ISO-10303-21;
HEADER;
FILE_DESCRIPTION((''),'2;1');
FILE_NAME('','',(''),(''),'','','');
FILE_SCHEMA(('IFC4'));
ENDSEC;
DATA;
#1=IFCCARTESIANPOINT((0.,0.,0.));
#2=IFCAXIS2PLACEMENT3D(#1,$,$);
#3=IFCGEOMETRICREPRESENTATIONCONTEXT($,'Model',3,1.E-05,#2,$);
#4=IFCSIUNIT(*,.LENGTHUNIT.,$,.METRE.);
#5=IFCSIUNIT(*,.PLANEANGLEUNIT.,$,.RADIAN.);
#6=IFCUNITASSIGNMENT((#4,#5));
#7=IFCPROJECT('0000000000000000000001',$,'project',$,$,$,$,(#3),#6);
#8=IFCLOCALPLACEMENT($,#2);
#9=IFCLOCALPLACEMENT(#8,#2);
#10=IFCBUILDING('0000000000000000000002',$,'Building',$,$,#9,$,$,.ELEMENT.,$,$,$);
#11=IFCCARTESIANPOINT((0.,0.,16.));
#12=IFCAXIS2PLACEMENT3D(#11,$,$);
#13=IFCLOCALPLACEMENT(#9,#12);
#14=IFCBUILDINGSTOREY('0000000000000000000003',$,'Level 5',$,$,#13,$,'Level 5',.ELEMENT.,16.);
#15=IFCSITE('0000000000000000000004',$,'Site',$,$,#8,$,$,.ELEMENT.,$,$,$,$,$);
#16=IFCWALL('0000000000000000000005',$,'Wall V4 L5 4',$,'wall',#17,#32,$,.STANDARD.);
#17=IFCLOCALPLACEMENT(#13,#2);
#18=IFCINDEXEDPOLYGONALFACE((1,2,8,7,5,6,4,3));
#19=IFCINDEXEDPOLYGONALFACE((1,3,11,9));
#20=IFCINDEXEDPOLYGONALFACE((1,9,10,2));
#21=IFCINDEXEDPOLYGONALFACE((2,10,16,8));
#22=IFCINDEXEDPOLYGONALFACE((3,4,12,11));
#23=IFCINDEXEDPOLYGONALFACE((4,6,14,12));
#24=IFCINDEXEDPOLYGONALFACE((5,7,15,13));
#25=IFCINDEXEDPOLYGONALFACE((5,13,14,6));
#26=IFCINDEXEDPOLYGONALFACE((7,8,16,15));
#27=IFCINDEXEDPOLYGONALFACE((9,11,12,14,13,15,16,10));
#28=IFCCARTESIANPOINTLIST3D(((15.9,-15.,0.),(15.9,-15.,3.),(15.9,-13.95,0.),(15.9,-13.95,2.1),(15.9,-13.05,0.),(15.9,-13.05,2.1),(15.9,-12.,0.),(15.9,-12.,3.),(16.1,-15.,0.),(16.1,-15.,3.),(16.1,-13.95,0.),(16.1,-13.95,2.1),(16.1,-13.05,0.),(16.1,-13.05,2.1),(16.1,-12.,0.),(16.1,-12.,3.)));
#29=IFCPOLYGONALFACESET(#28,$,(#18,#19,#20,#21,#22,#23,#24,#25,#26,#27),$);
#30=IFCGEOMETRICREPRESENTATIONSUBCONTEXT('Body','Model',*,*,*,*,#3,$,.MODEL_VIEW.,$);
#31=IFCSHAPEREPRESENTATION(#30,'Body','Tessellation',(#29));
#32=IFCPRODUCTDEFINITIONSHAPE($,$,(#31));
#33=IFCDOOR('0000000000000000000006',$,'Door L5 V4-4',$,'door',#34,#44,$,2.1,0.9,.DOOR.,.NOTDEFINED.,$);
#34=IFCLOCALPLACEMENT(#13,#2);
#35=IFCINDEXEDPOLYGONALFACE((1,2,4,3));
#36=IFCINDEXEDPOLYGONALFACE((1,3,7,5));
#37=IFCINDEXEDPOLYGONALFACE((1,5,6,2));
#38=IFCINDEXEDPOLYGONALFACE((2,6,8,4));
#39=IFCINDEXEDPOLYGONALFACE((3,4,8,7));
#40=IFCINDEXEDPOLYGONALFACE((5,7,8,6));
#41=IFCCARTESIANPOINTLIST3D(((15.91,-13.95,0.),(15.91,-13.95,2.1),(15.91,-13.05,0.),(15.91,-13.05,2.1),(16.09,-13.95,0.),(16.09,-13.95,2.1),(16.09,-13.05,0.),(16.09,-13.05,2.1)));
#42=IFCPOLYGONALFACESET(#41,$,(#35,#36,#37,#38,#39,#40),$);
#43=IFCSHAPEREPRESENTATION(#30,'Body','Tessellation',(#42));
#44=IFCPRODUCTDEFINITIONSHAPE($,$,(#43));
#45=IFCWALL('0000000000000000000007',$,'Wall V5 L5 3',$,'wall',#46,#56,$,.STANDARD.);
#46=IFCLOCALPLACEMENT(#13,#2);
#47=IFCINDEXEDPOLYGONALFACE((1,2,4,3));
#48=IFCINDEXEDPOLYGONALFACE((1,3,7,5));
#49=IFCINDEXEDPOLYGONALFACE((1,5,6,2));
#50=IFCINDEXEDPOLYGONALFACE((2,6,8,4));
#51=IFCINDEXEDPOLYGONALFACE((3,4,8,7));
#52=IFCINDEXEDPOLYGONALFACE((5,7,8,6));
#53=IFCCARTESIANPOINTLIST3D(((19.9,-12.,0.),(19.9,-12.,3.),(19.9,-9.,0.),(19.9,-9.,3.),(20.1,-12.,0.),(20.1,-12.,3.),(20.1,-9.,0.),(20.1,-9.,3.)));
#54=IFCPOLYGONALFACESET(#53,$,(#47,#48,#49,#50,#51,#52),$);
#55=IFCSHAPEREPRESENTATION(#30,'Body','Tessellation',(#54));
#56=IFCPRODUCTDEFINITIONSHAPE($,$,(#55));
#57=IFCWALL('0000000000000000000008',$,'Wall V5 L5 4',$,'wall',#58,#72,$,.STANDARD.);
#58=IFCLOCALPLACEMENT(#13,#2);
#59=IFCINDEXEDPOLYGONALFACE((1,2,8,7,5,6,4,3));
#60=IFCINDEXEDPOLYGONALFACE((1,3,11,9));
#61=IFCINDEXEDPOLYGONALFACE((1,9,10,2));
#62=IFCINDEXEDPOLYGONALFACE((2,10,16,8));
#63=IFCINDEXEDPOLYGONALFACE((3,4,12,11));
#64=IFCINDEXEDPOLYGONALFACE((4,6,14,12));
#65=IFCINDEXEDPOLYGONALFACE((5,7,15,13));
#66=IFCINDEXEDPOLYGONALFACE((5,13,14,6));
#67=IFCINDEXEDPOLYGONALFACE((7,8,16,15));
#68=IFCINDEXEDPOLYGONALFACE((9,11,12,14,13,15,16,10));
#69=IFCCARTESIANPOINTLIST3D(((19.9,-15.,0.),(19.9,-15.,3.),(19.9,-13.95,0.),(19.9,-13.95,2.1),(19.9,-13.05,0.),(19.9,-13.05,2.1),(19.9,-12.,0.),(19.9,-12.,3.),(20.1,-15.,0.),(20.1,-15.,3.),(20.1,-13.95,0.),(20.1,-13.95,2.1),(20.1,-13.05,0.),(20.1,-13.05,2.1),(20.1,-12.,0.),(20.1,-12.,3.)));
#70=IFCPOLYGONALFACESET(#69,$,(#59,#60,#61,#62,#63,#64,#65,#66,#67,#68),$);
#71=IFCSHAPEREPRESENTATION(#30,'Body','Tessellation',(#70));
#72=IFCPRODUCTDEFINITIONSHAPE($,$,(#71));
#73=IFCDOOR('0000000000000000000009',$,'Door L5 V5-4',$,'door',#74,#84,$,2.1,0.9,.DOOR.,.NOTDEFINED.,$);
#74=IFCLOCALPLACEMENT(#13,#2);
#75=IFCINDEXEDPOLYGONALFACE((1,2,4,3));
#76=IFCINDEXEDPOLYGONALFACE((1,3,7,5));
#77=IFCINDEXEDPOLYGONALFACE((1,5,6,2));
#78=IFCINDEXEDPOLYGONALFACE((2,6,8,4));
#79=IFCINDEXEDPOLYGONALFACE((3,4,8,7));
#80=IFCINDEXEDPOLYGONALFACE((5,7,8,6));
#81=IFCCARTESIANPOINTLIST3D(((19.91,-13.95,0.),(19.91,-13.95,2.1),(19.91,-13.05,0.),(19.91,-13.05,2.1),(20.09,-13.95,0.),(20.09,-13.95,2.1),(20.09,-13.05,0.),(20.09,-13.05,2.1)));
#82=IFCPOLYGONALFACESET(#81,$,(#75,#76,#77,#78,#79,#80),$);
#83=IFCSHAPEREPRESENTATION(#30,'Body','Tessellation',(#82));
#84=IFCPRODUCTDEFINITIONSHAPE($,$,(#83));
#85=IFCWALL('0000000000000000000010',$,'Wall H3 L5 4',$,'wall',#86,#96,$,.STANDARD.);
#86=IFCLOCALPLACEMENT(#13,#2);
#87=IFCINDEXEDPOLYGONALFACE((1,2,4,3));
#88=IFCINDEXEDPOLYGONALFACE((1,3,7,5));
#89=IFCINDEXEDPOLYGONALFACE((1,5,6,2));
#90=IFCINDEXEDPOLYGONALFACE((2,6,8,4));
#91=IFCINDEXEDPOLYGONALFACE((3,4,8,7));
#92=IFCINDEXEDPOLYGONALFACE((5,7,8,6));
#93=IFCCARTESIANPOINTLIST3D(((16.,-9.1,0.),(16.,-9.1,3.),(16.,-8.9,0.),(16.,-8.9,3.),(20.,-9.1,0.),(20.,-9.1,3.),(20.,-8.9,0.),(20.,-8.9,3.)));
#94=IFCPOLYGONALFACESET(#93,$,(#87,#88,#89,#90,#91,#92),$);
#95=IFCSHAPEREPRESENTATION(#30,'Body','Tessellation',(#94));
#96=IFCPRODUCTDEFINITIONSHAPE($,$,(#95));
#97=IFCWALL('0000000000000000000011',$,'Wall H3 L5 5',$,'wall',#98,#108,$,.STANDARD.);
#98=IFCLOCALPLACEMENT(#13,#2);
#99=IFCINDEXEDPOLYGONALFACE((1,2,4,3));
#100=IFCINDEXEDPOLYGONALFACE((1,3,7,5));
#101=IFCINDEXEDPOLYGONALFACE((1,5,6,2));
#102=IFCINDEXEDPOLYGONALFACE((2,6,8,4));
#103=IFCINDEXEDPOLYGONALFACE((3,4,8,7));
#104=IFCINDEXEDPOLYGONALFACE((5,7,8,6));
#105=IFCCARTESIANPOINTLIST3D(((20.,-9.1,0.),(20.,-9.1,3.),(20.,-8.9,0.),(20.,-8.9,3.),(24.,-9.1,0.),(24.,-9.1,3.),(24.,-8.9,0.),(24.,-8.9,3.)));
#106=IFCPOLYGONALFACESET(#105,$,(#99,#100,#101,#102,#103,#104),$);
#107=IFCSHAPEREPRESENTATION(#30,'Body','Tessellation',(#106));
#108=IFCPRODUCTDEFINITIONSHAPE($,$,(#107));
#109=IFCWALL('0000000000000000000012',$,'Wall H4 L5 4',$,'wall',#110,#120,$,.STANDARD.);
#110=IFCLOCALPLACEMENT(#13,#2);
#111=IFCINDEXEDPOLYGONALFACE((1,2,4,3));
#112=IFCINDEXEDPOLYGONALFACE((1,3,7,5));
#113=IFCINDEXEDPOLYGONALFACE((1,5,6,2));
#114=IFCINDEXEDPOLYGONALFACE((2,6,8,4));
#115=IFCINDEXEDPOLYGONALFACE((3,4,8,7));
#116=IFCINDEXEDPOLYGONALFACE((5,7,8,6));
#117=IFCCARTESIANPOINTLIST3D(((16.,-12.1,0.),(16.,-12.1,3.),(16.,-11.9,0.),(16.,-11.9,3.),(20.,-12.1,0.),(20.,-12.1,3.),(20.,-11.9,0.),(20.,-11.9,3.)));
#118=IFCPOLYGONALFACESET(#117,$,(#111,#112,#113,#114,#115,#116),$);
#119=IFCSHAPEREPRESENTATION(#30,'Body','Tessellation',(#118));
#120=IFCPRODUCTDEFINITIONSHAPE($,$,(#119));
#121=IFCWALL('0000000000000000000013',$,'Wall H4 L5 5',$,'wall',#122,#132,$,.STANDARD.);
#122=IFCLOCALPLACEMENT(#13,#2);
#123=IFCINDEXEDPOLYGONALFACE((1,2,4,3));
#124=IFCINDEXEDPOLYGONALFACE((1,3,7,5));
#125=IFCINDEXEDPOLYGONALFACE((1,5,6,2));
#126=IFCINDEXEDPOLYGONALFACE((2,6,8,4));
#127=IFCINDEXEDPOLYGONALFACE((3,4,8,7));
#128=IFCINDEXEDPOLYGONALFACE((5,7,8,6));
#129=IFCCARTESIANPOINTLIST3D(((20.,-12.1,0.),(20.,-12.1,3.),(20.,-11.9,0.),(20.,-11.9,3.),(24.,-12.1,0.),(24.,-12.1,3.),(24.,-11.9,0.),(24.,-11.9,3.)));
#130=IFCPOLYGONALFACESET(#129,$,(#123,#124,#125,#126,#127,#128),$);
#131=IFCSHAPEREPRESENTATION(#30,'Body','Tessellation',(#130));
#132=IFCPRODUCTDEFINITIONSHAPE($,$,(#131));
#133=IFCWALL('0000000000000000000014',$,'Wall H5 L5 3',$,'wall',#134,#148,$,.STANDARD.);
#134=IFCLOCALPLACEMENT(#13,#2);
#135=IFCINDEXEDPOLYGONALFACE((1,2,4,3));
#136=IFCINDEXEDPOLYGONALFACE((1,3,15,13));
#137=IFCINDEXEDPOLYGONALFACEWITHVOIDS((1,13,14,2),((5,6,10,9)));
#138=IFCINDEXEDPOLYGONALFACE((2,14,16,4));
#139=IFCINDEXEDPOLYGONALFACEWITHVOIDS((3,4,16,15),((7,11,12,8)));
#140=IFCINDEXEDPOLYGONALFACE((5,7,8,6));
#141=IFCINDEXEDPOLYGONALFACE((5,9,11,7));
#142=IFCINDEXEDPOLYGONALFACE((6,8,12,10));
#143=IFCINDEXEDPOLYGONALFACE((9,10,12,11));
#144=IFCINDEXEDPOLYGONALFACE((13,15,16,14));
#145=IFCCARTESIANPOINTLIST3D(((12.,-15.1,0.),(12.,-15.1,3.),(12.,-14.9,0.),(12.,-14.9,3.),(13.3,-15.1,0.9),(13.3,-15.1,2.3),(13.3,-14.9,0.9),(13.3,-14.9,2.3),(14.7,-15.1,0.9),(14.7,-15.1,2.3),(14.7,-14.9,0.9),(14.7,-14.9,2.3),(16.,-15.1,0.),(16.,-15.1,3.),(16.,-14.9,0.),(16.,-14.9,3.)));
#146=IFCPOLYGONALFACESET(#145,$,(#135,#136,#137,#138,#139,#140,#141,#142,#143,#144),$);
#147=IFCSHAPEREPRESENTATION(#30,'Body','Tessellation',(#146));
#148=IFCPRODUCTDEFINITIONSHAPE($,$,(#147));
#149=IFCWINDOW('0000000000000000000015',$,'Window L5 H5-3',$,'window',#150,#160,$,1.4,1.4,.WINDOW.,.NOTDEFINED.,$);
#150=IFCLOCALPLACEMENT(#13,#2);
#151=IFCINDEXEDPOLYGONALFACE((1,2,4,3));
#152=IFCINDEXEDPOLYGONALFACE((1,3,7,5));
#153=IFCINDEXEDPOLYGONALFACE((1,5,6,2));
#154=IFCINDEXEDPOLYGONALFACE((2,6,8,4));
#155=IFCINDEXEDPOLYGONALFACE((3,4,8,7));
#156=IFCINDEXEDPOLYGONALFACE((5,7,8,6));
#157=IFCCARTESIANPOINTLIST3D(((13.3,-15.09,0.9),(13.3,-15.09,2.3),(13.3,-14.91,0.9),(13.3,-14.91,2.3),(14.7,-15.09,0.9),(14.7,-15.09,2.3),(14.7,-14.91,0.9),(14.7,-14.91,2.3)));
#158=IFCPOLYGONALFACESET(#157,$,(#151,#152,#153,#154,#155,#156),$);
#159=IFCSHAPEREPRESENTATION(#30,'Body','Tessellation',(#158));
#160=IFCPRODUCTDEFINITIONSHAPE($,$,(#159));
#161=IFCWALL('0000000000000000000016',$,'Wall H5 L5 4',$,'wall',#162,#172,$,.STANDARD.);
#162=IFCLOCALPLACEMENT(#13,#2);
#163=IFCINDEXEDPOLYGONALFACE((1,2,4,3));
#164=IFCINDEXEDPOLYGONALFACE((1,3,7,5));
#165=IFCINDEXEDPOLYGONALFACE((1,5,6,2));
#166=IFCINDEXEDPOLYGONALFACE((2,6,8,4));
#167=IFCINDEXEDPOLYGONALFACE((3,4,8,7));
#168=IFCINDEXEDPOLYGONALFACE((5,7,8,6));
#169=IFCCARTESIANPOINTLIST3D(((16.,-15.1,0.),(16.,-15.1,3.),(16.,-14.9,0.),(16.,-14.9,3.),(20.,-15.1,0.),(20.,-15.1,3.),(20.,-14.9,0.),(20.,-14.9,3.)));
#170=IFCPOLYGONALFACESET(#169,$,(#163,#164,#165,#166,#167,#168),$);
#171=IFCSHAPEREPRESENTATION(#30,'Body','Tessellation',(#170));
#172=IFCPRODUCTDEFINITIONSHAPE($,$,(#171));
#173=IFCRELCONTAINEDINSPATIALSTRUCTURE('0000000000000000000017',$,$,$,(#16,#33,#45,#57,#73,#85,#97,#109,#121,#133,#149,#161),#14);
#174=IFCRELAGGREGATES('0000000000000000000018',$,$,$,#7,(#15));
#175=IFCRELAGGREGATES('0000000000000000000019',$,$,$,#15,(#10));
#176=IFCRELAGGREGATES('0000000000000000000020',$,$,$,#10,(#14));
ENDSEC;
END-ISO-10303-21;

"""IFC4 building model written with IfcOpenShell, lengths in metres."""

from ifc_helpers import new_model, si_unit, frame, frame_2d, origin, origin_2d, place, context, subcontext, project, spatial, rectangle, extrude, element, fill, save


model = new_model("IFC4")

# Units and contexts
model_context = context("Model", 3, precision=1e-05, world=origin())
body_context = subcontext(model_context, "Body", "Model", "MODEL_VIEW")
ifc_project = project(units=[si_unit("LENGTHUNIT", "METRE"), si_unit("PLANEANGLEUNIT", "RADIAN")], contexts=[model_context])

# Site, building, storey
site_placement = place(None, origin())
site = spatial("IfcSite", under=ifc_project, at=site_placement, Name="Site", CompositionType="ELEMENT")
building_placement = place(site_placement, origin())
building = spatial("IfcBuilding", under=site, at=building_placement, Name="Building", CompositionType="ELEMENT")
storey_placement = place(building_placement, frame((0.0, 0.0, 16.0)))
storey = spatial("IfcBuildingStorey", under=building, at=storey_placement, Name="Level 5", LongName="Level 5", CompositionType="ELEMENT", Elevation=16.0)

# Wall, opening, door
wall_1_placement = place(storey_placement, frame((16.0, -12.0, 0.0), z_axis=(0.0, 0.0, 1.0), x_axis=(0.0, -1.0, 0.0)))
wall_1 = element("IfcWall", 1, at=wall_1_placement, inside=storey, Name="Wall V4 L5 4", ObjectType="wall", PredefinedType="STANDARD", context=body_context, shape_type="SweptSolid", body=[
    extrude(rectangle(XDim=3.0, YDim=0.2, at=frame_2d((1.5, 0.0))), origin(), (0.0, 0.0, 1.0), 3.0),
])
opening_1_placement = place(storey_placement, frame((16.0, -13.5, 0.0), z_axis=(0.0, 0.0, 1.0), x_axis=(0.0, -1.0, 0.0)))
opening_1 = element("IfcOpeningElement", 2, at=opening_1_placement, cuts=wall_1, ObjectType="Opening", PredefinedType="OPENING", context=body_context, shape_type="SweptSolid", body=[
    extrude(rectangle(XDim=0.9, YDim=0.22, at=origin_2d()), origin(), (0.0, 0.0, 1.0), 2.1),
])
door_1_placement = place(storey_placement, frame((16.0, -13.5, 0.0), z_axis=(0.0, 0.0, 1.0), x_axis=(0.0, -1.0, 0.0)))
door_1 = element("IfcDoor", 3, at=door_1_placement, inside=storey, Name="Door L5 V4-4", ObjectType="door", OperationType="NOTDEFINED", OverallHeight=2.1, OverallWidth=0.9, PredefinedType="DOOR", context=body_context, shape_type="SweptSolid", body=[
    extrude(rectangle(XDim=0.9, YDim=0.18, at=origin_2d()), origin(), (0.0, 0.0, 1.0), 2.1),
])
fill(opening_1, door_1)

# Wall
wall_2_placement = place(storey_placement, frame((20.0, -9.0, 0.0), z_axis=(0.0, 0.0, 1.0), x_axis=(0.0, -1.0, 0.0)))
element("IfcWall", 4, at=wall_2_placement, inside=storey, Name="Wall V5 L5 3", ObjectType="wall", PredefinedType="STANDARD", context=body_context, shape_type="SweptSolid", body=[
    extrude(rectangle(XDim=3.0, YDim=0.2, at=frame_2d((1.5, 0.0))), origin(), (0.0, 0.0, 1.0), 3.0),
])

# Wall, opening, door
wall_3_placement = place(storey_placement, frame((20.0, -12.0, 0.0), z_axis=(0.0, 0.0, 1.0), x_axis=(0.0, -1.0, 0.0)))
wall_3 = element("IfcWall", 5, at=wall_3_placement, inside=storey, Name="Wall V5 L5 4", ObjectType="wall", PredefinedType="STANDARD", context=body_context, shape_type="SweptSolid", body=[
    extrude(rectangle(XDim=3.0, YDim=0.2, at=frame_2d((1.5, 0.0))), origin(), (0.0, 0.0, 1.0), 3.0),
])
opening_2_placement = place(storey_placement, frame((20.0, -13.5, 0.0), z_axis=(0.0, 0.0, 1.0), x_axis=(0.0, -1.0, 0.0)))
opening_2 = element("IfcOpeningElement", 6, at=opening_2_placement, cuts=wall_3, ObjectType="Opening", PredefinedType="OPENING", context=body_context, shape_type="SweptSolid", body=[
    extrude(rectangle(XDim=0.9, YDim=0.22, at=origin_2d()), origin(), (0.0, 0.0, 1.0), 2.1),
])
door_2_placement = place(storey_placement, frame((20.0, -13.5, 0.0), z_axis=(0.0, 0.0, 1.0), x_axis=(0.0, -1.0, 0.0)))
door_2 = element("IfcDoor", 7, at=door_2_placement, inside=storey, Name="Door L5 V5-4", ObjectType="door", OperationType="NOTDEFINED", OverallHeight=2.1, OverallWidth=0.9, PredefinedType="DOOR", context=body_context, shape_type="SweptSolid", body=[
    extrude(rectangle(XDim=0.9, YDim=0.18, at=origin_2d()), origin(), (0.0, 0.0, 1.0), 2.1),
])
fill(opening_2, door_2)

# Walls
for number, where, z_axis, x_axis, name in (
    (8, (16.0, -9.0, 0.0), (0.0, 0.0, 1.0), (1.0, 0.0, 0.0), "Wall H3 L5 4"),
    (9, (20.0, -9.0, 0.0), (0.0, 0.0, 1.0), (1.0, 0.0, 0.0), "Wall H3 L5 5"),
    (10, (16.0, -12.0, 0.0), (0.0, 0.0, 1.0), (1.0, 0.0, 0.0), "Wall H4 L5 4"),
    (11, (20.0, -12.0, 0.0), (0.0, 0.0, 1.0), (1.0, 0.0, 0.0), "Wall H4 L5 5"),
):
    element("IfcWall", number, at=place(storey_placement, frame(where, z_axis=z_axis, x_axis=x_axis)), inside=storey, Name=name, ObjectType="wall", PredefinedType="STANDARD", context=body_context, shape_type="SweptSolid", body=[
        extrude(rectangle(XDim=4.0, YDim=0.2, at=frame_2d((2.0, 0.0))), origin(), (0.0, 0.0, 1.0), 3.0),
    ])

# Wall, opening, window
wall_4_placement = place(storey_placement, frame((12.0, -15.0, 0.0), z_axis=(0.0, 0.0, 1.0), x_axis=(1.0, 0.0, 0.0)))
wall_4 = element("IfcWall", 12, at=wall_4_placement, inside=storey, Name="Wall H5 L5 3", ObjectType="wall", PredefinedType="STANDARD", context=body_context, shape_type="SweptSolid", body=[
    extrude(rectangle(XDim=4.0, YDim=0.2, at=frame_2d((2.0, 0.0))), origin(), (0.0, 0.0, 1.0), 3.0),
])
opening_3_placement = place(storey_placement, frame((14.0, -15.0, 0.9), z_axis=(0.0, 0.0, 1.0), x_axis=(1.0, 0.0, 0.0)))
opening_3 = element("IfcOpeningElement", 13, at=opening_3_placement, cuts=wall_4, ObjectType="Opening", PredefinedType="OPENING", context=body_context, shape_type="SweptSolid", body=[
    extrude(rectangle(XDim=1.4, YDim=0.22, at=origin_2d()), origin(), (0.0, 0.0, 1.0), 1.4),
])
window_1_placement = place(storey_placement, frame((14.0, -15.0, 0.9), z_axis=(0.0, 0.0, 1.0), x_axis=(1.0, 0.0, 0.0)))
window_1 = element("IfcWindow", 14, at=window_1_placement, inside=storey, Name="Window L5 H5-3", ObjectType="window", OverallHeight=1.4, OverallWidth=1.4, PartitioningType="NOTDEFINED", PredefinedType="WINDOW", context=body_context, shape_type="SweptSolid", body=[
    extrude(rectangle(XDim=1.4, YDim=0.18, at=origin_2d()), origin(), (0.0, 0.0, 1.0), 1.4),
])
fill(opening_3, window_1)

# Wall
wall_5_placement = place(storey_placement, frame((16.0, -15.0, 0.0), z_axis=(0.0, 0.0, 1.0), x_axis=(1.0, 0.0, 0.0)))
element("IfcWall", 15, at=wall_5_placement, inside=storey, Name="Wall H5 L5 4", ObjectType="wall", PredefinedType="STANDARD", context=body_context, shape_type="SweptSolid", body=[
    extrude(rectangle(XDim=4.0, YDim=0.2, at=frame_2d((2.0, 0.0))), origin(), (0.0, 0.0, 1.0), 3.0),
])

save(model, "model.ifc")
